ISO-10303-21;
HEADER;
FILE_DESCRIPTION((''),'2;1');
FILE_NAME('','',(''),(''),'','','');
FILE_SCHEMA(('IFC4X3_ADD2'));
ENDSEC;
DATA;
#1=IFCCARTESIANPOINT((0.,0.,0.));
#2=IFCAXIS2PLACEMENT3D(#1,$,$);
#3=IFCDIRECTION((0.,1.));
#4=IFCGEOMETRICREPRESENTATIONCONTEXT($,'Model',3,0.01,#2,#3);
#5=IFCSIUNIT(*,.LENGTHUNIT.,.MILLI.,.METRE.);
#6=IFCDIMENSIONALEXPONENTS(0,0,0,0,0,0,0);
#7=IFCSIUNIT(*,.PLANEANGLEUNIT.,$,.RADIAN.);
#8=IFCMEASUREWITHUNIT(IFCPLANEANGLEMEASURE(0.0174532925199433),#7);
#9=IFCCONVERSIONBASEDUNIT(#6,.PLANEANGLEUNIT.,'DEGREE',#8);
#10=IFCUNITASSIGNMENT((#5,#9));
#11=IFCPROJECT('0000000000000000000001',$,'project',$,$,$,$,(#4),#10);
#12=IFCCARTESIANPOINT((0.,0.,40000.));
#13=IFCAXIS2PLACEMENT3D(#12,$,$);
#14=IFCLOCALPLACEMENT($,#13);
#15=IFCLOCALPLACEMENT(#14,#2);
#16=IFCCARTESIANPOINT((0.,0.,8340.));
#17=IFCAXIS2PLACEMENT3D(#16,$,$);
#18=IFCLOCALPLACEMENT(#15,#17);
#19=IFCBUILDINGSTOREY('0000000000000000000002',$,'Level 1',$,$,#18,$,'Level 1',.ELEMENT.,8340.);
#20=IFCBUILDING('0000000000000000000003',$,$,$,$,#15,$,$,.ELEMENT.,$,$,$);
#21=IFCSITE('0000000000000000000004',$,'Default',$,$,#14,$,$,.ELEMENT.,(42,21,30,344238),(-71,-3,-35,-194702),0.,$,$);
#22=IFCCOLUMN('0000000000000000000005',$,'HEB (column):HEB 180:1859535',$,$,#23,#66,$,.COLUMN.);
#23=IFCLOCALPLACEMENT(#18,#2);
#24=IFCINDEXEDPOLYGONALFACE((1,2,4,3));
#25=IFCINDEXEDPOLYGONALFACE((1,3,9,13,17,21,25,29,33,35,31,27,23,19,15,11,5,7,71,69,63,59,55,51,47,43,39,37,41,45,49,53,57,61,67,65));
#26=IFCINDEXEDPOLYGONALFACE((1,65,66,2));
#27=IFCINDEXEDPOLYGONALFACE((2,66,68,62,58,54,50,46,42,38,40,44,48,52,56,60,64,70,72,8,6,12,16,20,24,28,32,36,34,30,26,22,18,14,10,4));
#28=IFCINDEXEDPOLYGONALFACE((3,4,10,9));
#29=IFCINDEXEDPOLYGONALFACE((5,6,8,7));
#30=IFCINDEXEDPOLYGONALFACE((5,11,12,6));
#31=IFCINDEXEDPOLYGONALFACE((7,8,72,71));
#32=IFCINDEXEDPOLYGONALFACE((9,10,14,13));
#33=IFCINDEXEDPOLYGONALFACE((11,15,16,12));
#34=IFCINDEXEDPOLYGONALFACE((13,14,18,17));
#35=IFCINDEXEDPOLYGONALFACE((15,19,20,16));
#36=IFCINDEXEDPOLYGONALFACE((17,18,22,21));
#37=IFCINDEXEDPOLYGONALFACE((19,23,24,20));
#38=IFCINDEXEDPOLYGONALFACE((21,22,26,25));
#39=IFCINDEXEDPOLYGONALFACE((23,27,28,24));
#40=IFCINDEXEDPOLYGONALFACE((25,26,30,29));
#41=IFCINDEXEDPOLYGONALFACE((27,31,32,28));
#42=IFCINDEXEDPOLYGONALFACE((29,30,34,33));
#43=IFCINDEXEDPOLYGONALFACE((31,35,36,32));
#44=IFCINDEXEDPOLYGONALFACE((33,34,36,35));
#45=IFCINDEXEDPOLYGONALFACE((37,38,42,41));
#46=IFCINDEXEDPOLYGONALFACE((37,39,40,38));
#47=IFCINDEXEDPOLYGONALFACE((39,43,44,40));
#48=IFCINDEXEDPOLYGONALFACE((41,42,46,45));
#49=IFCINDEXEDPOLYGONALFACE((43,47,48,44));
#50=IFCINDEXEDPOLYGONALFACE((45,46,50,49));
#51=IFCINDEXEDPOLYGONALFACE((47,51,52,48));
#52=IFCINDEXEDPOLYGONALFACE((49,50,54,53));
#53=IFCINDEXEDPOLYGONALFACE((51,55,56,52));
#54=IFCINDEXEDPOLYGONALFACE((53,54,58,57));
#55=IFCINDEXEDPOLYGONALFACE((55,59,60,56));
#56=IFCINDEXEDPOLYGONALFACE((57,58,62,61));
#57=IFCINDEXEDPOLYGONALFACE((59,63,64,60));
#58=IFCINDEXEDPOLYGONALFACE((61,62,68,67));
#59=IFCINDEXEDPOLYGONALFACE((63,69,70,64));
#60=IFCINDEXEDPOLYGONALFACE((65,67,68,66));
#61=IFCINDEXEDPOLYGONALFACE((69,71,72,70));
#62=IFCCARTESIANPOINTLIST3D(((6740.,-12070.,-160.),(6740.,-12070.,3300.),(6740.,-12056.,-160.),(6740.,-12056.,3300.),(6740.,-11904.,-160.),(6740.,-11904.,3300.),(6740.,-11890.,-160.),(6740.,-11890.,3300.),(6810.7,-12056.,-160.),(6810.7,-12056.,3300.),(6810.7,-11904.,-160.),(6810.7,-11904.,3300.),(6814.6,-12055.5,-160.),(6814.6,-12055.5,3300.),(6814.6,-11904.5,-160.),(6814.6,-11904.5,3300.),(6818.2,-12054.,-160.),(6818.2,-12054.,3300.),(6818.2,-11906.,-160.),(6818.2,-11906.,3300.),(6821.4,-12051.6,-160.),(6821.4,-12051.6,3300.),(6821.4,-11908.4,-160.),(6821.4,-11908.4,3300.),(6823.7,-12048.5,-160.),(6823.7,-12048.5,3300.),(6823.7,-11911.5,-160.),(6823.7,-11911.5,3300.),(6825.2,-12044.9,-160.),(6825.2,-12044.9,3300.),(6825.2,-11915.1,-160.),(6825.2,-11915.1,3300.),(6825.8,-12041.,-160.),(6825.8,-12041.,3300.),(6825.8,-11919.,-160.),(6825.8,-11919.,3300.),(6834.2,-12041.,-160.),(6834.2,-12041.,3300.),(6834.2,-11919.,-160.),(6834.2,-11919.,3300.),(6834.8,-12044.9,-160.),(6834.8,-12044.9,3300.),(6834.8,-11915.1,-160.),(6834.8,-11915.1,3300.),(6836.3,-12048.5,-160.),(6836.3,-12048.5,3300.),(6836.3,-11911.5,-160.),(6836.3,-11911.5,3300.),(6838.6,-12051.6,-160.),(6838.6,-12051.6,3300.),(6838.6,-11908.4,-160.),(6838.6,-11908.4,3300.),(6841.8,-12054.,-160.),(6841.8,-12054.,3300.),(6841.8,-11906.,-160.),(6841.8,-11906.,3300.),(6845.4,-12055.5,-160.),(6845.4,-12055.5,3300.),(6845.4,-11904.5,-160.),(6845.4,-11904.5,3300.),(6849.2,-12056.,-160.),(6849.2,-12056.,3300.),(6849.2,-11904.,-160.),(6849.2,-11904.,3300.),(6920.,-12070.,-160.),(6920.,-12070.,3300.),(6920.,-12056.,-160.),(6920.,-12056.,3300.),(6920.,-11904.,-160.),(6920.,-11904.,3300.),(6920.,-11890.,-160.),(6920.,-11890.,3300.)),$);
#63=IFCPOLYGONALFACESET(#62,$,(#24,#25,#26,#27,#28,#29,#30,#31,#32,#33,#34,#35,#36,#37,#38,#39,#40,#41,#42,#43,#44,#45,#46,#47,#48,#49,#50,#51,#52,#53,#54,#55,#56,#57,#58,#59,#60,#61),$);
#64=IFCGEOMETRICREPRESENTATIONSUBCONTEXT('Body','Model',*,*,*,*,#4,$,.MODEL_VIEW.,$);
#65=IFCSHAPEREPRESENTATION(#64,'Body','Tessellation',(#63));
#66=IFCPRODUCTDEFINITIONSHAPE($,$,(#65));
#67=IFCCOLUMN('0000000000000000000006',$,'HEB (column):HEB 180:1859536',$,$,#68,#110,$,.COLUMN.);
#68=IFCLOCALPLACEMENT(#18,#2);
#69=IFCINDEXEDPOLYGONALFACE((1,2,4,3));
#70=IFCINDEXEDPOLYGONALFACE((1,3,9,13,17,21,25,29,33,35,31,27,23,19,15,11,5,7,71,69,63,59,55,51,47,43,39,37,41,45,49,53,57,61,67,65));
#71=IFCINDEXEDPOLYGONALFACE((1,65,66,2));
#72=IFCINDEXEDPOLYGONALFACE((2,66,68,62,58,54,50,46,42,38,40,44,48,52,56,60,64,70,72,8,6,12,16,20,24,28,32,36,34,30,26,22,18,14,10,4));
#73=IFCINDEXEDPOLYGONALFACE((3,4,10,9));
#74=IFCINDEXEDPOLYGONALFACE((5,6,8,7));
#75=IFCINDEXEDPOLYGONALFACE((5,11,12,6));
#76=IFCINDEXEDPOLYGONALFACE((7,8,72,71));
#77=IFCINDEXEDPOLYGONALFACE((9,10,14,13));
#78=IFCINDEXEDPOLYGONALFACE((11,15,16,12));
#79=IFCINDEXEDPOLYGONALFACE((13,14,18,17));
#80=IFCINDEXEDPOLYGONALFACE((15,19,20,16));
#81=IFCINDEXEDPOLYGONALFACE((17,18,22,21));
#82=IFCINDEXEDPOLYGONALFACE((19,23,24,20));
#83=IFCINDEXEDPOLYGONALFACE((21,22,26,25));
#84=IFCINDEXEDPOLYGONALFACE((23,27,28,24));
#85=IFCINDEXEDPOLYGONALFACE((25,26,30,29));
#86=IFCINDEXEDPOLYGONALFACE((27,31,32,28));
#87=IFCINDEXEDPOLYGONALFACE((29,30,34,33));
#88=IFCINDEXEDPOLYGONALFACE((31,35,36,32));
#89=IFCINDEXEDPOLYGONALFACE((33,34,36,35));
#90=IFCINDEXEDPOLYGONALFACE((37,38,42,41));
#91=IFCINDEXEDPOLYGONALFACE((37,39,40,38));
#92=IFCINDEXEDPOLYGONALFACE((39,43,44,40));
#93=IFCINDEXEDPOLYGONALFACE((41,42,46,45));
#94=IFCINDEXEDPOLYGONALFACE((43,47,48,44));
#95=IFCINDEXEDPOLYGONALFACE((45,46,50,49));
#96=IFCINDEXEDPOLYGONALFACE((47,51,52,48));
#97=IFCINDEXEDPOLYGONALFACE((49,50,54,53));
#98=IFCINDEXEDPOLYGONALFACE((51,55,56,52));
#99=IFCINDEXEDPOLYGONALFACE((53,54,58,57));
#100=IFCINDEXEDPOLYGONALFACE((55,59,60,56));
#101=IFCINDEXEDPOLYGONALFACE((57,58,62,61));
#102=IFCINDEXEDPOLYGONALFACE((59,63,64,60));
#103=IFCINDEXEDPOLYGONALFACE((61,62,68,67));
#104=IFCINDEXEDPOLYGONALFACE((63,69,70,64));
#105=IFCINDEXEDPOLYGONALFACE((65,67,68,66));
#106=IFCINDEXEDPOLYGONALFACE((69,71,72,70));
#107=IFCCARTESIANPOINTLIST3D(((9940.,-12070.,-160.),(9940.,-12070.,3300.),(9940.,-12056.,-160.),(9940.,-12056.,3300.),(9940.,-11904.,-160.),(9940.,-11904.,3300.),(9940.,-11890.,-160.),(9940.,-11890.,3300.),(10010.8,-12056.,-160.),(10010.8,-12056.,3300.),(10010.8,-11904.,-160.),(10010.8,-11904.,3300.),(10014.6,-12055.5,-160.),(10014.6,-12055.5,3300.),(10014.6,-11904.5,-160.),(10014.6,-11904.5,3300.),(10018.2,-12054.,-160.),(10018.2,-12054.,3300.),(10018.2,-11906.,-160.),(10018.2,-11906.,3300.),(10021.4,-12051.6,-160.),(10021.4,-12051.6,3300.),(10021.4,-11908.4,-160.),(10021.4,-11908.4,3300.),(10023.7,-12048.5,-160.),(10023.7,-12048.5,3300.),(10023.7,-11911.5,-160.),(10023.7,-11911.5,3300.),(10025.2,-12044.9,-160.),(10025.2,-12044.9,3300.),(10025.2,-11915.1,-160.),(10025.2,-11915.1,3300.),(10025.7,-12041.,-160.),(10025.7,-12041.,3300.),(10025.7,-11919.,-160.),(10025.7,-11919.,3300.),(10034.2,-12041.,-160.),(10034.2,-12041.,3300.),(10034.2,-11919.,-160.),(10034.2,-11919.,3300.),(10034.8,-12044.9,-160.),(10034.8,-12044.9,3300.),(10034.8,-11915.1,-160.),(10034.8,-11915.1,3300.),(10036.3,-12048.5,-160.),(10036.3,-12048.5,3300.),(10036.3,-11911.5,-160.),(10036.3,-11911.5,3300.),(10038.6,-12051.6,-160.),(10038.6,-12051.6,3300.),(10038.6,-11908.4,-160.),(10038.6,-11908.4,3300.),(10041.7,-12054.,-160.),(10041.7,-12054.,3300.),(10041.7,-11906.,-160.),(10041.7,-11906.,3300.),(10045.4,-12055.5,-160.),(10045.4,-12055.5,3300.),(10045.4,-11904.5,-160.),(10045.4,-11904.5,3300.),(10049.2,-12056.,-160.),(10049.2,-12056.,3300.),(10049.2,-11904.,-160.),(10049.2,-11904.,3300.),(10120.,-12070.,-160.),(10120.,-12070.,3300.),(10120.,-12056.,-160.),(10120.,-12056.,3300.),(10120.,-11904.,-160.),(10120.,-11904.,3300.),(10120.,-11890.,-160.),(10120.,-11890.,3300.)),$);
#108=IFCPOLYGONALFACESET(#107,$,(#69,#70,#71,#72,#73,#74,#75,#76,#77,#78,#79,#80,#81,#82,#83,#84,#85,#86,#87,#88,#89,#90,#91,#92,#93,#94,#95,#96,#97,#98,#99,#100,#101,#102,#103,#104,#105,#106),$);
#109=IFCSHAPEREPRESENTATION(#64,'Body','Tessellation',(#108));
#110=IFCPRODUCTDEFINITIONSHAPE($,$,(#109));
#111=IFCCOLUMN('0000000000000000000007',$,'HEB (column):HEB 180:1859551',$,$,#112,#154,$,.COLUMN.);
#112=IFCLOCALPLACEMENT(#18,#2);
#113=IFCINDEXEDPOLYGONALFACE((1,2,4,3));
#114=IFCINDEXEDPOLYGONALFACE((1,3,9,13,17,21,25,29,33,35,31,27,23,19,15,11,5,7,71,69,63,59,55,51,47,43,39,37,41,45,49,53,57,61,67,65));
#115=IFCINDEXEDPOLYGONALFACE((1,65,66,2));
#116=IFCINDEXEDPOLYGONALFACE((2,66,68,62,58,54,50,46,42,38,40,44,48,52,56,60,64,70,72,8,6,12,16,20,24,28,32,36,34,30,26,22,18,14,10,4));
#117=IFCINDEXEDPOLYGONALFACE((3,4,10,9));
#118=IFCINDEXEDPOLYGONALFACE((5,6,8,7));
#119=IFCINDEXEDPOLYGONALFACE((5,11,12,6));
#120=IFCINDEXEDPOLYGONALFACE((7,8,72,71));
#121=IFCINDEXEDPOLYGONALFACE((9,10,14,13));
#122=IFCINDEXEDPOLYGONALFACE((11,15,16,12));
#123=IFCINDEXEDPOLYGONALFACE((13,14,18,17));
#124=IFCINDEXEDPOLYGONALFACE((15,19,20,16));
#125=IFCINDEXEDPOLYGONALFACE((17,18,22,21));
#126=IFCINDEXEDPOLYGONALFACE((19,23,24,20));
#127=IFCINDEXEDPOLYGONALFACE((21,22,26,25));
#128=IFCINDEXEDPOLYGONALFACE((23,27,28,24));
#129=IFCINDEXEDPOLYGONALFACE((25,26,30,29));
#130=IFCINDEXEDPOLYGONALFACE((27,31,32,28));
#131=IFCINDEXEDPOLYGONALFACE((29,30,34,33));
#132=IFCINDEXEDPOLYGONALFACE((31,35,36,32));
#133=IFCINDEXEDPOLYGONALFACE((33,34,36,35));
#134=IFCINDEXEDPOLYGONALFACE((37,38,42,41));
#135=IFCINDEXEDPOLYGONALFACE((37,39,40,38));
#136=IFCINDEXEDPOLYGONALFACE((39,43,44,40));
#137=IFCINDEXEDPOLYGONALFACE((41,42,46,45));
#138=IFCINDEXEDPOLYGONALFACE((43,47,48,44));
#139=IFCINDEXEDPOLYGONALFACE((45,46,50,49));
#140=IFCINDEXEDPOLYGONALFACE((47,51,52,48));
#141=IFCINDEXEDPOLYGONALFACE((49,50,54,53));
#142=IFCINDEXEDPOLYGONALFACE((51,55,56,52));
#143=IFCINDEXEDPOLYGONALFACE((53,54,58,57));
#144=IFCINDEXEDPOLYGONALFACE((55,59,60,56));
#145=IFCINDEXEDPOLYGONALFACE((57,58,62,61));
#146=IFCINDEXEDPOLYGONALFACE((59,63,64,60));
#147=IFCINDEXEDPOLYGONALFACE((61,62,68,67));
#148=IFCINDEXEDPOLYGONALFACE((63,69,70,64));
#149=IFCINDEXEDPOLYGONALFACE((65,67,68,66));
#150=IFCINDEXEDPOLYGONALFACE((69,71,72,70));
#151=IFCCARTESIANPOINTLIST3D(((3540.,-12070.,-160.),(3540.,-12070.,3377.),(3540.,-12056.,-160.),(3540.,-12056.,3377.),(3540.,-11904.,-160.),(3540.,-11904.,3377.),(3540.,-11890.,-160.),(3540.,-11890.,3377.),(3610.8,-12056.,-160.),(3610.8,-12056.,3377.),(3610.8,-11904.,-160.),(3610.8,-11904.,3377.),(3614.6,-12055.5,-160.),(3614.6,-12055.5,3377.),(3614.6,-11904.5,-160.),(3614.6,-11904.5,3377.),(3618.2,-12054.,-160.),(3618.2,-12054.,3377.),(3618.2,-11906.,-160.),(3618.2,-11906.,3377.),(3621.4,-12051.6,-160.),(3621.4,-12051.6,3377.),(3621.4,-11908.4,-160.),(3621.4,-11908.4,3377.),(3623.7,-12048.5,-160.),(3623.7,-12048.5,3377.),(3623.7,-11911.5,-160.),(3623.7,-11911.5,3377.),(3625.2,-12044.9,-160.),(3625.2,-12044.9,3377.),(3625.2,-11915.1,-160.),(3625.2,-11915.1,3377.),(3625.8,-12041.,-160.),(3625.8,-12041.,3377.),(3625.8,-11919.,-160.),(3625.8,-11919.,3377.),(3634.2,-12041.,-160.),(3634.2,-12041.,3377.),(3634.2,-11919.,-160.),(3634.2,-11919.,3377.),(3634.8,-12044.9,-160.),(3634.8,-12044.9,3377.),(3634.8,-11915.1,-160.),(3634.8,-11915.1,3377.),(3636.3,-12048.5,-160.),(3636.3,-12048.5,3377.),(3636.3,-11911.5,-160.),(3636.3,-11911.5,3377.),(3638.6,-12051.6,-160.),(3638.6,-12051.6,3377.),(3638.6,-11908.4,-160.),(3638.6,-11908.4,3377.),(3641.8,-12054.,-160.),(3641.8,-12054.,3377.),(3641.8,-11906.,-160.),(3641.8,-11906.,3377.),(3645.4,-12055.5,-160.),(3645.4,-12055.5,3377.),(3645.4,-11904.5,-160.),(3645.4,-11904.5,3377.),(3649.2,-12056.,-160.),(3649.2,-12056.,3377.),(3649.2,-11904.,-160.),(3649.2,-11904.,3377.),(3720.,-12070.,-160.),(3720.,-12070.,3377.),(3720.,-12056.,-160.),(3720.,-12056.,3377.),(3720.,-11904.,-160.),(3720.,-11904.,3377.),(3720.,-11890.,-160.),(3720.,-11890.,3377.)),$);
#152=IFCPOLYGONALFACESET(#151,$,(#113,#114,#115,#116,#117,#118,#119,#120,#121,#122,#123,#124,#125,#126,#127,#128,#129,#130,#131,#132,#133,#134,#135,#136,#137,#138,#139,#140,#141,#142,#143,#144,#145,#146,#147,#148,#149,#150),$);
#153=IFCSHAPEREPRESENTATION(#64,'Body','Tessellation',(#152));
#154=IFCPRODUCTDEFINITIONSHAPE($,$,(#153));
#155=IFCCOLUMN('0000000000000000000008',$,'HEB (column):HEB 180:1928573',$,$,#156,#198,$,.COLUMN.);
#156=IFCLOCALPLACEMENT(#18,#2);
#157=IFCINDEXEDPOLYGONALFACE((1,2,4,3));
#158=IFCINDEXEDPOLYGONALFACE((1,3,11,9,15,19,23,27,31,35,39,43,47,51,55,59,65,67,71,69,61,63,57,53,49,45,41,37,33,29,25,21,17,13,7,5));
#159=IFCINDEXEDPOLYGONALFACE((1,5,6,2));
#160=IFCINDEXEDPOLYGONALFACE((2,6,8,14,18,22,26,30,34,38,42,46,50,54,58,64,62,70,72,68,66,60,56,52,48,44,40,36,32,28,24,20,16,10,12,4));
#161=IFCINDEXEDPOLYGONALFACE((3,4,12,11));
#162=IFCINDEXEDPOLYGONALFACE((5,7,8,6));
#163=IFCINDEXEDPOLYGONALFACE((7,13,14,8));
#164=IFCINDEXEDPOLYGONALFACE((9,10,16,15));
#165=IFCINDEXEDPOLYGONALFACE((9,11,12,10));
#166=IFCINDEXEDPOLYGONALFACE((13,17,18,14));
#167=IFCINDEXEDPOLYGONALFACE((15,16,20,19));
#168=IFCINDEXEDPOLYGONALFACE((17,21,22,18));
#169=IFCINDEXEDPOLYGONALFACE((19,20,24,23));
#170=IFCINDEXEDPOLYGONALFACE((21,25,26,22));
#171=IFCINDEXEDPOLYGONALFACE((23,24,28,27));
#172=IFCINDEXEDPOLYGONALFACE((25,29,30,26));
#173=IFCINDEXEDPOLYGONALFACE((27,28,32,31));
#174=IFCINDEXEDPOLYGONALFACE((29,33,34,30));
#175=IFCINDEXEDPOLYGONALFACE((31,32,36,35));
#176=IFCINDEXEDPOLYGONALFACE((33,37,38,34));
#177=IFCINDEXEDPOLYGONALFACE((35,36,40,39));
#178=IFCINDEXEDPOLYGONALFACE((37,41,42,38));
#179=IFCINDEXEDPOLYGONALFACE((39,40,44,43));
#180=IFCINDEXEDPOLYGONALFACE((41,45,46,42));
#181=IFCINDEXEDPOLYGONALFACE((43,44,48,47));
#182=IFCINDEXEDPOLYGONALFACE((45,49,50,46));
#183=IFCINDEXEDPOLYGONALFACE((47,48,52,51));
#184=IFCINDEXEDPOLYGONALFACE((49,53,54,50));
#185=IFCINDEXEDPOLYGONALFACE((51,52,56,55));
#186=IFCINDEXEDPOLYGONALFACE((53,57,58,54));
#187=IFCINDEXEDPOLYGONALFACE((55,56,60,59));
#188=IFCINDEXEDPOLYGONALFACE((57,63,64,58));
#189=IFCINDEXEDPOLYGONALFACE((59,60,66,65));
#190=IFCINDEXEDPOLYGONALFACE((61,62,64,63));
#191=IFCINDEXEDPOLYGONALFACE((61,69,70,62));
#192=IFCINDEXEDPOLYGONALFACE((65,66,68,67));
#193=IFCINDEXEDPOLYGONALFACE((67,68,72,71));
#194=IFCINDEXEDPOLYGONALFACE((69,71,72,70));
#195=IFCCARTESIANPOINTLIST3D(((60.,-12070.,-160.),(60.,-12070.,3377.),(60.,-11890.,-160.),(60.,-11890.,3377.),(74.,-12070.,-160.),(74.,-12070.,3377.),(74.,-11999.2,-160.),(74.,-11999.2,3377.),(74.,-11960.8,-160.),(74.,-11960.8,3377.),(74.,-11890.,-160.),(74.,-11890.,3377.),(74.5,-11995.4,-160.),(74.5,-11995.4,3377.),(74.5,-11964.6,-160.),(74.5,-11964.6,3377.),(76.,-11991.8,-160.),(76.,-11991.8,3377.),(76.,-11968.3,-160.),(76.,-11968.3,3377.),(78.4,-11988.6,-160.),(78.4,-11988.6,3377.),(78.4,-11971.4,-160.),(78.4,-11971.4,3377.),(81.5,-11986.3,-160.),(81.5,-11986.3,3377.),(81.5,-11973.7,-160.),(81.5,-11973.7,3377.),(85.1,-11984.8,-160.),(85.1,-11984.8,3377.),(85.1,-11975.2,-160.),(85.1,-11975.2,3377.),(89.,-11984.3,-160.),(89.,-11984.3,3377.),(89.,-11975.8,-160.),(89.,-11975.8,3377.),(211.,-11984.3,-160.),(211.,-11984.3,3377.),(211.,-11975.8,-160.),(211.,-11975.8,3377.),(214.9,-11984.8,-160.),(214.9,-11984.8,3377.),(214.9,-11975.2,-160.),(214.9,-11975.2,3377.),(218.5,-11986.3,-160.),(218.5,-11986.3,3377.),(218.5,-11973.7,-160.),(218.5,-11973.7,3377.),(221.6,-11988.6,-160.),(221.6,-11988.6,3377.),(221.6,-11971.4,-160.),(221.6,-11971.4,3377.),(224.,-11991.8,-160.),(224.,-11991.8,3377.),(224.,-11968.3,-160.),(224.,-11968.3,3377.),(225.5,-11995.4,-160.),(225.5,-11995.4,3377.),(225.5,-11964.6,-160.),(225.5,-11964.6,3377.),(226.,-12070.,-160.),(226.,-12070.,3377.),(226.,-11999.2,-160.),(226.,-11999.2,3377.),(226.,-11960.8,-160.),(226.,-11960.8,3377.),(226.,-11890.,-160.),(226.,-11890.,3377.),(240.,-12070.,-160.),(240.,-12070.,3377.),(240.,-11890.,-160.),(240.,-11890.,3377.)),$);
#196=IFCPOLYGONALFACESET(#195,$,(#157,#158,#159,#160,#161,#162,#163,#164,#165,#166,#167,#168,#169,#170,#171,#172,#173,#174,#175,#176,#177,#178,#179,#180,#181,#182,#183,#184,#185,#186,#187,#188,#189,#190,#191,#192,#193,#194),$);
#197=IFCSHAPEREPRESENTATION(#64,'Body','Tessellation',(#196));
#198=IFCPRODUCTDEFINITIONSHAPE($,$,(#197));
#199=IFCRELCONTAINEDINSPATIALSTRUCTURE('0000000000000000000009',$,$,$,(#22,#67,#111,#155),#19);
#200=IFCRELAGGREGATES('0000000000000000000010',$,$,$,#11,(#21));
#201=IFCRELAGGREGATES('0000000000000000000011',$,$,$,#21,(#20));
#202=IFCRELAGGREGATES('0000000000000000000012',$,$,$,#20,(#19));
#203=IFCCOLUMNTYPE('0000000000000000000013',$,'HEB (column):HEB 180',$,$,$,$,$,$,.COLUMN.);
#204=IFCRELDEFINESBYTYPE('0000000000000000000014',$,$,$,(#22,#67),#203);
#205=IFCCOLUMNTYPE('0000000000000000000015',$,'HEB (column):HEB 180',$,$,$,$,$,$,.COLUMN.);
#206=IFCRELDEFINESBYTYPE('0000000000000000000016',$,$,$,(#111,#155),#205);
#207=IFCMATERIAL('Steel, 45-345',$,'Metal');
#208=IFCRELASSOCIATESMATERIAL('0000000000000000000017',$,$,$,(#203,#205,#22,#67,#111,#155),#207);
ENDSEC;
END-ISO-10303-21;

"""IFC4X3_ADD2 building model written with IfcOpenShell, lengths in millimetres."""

from ifc_helpers import new_model, entity, si_unit, converted_unit, direction, frame, origin, origin_2d_with_axis, place, context, subcontext, project, spatial, i_section, extrude, source, transform, mapped, material, material_profile, profile_set, profile_usage, type_object, type_shapes, element, save


model = new_model("IFC4X3_ADD2")

# Units and contexts
model_context = context("Model", 3, precision=0.01, world=origin(), true_north=direction((0.0, 1.0)))
body_context = subcontext(model_context, "Body", "Model", "MODEL_VIEW")
ifc_project = project(units=[si_unit("LENGTHUNIT", "METRE", prefix="MILLI"), converted_unit("PLANEANGLEUNIT", "DEGREE", entity("IfcPlaneAngleMeasure", 0.0174532925199433), si_unit("PLANEANGLEUNIT", "RADIAN"), dimensions=[0, 0, 0, 0, 0, 0, 0])], contexts=[model_context])

# Site, building, storey
site_placement = place(None, frame((0.0, 0.0, 40000.0)))
site = spatial("IfcSite", under=ifc_project, at=site_placement, Name="Default", CompositionType="ELEMENT", RefLatitude=(42, 21, 30, 344238), RefLongitude=(-71, -3, -35, -194702), RefElevation=0.0)
building_placement = place(site_placement, origin())
building = spatial("IfcBuilding", under=site, at=building_placement, CompositionType="ELEMENT")
storey_placement = place(building_placement, frame((0.0, 0.0, 8340.0)))
storey = spatial("IfcBuildingStorey", under=building, at=storey_placement, Name="Level 1", LongName="Level 1", CompositionType="ELEMENT", Elevation=8340.0)

# Columns
ifc_material_1 = material(Name="Steel, 45-345", Category="Metal")
ifc_material_profile_1 = material_profile(ifc_material_1, i_section(OverallWidth=180.0, OverallDepth=180.0, WebThickness=8.5, FlangeThickness=14.0, FilletRadius=15.0, at=origin_2d_with_axis()), Name="HEB 180")
ifc_profile_set_1 = profile_set([ifc_material_profile_1], Name="HEB 180")
ifc_profile_usage_1 = profile_usage(ifc_profile_set_1)
column_type_1 = type_object("IfcColumnType", Name="HEB (column):HEB 180", PredefinedType="COLUMN", material=ifc_profile_set_1)
shared_shape_1 = source(origin(), body_context, "Body", "SweptSolid", [
    extrude(i_section(OverallWidth=180.0, OverallDepth=180.0, WebThickness=8.5, FlangeThickness=14.0, FilletRadius=15.0, at=origin_2d_with_axis()), frame((0.0, 0.0, 8180.0), z_axis=(0.0, 0.0, 1.0), x_axis=(-1.0, 0.0, 0.0)), (0.0, 0.0, 1.0), 3460.0),
])
type_shapes(column_type_1, [shared_shape_1])
for number, where, name in (
    (1, (6830.0, -11980.0, -8340.0), "HEB (column):HEB 180:1859535"),
    (2, (10030.0, -11980.0, -8340.0), "HEB (column):HEB 180:1859536"),
):
    element("IfcColumn", number, at=place(storey_placement, frame(where)), inside=storey, type_object=column_type_1, material=ifc_profile_usage_1, Name=name, PredefinedType="COLUMN", context=body_context, shape_type="MappedRepresentation", body=[
        mapped(shared_shape_1, transform((0.0, 0.0, 0.0), scale=1.0)),
    ])
column_type_2 = type_object("IfcColumnType", Name="HEB (column):HEB 180", PredefinedType="COLUMN", material=ifc_profile_set_1)
shared_shape_2 = source(origin(), body_context, "Body", "SweptSolid", [
    extrude(i_section(OverallWidth=180.0, OverallDepth=180.0, WebThickness=8.5, FlangeThickness=14.0, FilletRadius=15.0, at=origin_2d_with_axis()), frame((0.0, 0.0, 8180.0), z_axis=(0.0, 0.0, 1.0), x_axis=(-1.0, 0.0, 0.0)), (0.0, 0.0, 1.0), 3537.0),
])
type_shapes(column_type_2, [shared_shape_2])
column_1_placement = place(storey_placement, frame((3630.0, -11980.0, -8340.0)))
element("IfcColumn", 3, at=column_1_placement, inside=storey, type_object=column_type_2, material=ifc_profile_usage_1, Name="HEB (column):HEB 180:1859551", PredefinedType="COLUMN", context=body_context, shape_type="MappedRepresentation", body=[
    mapped(shared_shape_2, transform((0.0, 0.0, 0.0), scale=1.0)),
])
column_2_placement = place(storey_placement, frame((150.0, -11980.0, -8340.0), z_axis=(0.0, 0.0, 1.0), x_axis=(0.0, 1.0, 0.0)))
element("IfcColumn", 4, at=column_2_placement, inside=storey, type_object=column_type_2, material=ifc_profile_usage_1, Name="HEB (column):HEB 180:1928573", PredefinedType="COLUMN", context=body_context, shape_type="MappedRepresentation", body=[
    mapped(shared_shape_2, transform((0.0, 0.0, 0.0), scale=1.0)),
])

save(model, "model.ifc")
